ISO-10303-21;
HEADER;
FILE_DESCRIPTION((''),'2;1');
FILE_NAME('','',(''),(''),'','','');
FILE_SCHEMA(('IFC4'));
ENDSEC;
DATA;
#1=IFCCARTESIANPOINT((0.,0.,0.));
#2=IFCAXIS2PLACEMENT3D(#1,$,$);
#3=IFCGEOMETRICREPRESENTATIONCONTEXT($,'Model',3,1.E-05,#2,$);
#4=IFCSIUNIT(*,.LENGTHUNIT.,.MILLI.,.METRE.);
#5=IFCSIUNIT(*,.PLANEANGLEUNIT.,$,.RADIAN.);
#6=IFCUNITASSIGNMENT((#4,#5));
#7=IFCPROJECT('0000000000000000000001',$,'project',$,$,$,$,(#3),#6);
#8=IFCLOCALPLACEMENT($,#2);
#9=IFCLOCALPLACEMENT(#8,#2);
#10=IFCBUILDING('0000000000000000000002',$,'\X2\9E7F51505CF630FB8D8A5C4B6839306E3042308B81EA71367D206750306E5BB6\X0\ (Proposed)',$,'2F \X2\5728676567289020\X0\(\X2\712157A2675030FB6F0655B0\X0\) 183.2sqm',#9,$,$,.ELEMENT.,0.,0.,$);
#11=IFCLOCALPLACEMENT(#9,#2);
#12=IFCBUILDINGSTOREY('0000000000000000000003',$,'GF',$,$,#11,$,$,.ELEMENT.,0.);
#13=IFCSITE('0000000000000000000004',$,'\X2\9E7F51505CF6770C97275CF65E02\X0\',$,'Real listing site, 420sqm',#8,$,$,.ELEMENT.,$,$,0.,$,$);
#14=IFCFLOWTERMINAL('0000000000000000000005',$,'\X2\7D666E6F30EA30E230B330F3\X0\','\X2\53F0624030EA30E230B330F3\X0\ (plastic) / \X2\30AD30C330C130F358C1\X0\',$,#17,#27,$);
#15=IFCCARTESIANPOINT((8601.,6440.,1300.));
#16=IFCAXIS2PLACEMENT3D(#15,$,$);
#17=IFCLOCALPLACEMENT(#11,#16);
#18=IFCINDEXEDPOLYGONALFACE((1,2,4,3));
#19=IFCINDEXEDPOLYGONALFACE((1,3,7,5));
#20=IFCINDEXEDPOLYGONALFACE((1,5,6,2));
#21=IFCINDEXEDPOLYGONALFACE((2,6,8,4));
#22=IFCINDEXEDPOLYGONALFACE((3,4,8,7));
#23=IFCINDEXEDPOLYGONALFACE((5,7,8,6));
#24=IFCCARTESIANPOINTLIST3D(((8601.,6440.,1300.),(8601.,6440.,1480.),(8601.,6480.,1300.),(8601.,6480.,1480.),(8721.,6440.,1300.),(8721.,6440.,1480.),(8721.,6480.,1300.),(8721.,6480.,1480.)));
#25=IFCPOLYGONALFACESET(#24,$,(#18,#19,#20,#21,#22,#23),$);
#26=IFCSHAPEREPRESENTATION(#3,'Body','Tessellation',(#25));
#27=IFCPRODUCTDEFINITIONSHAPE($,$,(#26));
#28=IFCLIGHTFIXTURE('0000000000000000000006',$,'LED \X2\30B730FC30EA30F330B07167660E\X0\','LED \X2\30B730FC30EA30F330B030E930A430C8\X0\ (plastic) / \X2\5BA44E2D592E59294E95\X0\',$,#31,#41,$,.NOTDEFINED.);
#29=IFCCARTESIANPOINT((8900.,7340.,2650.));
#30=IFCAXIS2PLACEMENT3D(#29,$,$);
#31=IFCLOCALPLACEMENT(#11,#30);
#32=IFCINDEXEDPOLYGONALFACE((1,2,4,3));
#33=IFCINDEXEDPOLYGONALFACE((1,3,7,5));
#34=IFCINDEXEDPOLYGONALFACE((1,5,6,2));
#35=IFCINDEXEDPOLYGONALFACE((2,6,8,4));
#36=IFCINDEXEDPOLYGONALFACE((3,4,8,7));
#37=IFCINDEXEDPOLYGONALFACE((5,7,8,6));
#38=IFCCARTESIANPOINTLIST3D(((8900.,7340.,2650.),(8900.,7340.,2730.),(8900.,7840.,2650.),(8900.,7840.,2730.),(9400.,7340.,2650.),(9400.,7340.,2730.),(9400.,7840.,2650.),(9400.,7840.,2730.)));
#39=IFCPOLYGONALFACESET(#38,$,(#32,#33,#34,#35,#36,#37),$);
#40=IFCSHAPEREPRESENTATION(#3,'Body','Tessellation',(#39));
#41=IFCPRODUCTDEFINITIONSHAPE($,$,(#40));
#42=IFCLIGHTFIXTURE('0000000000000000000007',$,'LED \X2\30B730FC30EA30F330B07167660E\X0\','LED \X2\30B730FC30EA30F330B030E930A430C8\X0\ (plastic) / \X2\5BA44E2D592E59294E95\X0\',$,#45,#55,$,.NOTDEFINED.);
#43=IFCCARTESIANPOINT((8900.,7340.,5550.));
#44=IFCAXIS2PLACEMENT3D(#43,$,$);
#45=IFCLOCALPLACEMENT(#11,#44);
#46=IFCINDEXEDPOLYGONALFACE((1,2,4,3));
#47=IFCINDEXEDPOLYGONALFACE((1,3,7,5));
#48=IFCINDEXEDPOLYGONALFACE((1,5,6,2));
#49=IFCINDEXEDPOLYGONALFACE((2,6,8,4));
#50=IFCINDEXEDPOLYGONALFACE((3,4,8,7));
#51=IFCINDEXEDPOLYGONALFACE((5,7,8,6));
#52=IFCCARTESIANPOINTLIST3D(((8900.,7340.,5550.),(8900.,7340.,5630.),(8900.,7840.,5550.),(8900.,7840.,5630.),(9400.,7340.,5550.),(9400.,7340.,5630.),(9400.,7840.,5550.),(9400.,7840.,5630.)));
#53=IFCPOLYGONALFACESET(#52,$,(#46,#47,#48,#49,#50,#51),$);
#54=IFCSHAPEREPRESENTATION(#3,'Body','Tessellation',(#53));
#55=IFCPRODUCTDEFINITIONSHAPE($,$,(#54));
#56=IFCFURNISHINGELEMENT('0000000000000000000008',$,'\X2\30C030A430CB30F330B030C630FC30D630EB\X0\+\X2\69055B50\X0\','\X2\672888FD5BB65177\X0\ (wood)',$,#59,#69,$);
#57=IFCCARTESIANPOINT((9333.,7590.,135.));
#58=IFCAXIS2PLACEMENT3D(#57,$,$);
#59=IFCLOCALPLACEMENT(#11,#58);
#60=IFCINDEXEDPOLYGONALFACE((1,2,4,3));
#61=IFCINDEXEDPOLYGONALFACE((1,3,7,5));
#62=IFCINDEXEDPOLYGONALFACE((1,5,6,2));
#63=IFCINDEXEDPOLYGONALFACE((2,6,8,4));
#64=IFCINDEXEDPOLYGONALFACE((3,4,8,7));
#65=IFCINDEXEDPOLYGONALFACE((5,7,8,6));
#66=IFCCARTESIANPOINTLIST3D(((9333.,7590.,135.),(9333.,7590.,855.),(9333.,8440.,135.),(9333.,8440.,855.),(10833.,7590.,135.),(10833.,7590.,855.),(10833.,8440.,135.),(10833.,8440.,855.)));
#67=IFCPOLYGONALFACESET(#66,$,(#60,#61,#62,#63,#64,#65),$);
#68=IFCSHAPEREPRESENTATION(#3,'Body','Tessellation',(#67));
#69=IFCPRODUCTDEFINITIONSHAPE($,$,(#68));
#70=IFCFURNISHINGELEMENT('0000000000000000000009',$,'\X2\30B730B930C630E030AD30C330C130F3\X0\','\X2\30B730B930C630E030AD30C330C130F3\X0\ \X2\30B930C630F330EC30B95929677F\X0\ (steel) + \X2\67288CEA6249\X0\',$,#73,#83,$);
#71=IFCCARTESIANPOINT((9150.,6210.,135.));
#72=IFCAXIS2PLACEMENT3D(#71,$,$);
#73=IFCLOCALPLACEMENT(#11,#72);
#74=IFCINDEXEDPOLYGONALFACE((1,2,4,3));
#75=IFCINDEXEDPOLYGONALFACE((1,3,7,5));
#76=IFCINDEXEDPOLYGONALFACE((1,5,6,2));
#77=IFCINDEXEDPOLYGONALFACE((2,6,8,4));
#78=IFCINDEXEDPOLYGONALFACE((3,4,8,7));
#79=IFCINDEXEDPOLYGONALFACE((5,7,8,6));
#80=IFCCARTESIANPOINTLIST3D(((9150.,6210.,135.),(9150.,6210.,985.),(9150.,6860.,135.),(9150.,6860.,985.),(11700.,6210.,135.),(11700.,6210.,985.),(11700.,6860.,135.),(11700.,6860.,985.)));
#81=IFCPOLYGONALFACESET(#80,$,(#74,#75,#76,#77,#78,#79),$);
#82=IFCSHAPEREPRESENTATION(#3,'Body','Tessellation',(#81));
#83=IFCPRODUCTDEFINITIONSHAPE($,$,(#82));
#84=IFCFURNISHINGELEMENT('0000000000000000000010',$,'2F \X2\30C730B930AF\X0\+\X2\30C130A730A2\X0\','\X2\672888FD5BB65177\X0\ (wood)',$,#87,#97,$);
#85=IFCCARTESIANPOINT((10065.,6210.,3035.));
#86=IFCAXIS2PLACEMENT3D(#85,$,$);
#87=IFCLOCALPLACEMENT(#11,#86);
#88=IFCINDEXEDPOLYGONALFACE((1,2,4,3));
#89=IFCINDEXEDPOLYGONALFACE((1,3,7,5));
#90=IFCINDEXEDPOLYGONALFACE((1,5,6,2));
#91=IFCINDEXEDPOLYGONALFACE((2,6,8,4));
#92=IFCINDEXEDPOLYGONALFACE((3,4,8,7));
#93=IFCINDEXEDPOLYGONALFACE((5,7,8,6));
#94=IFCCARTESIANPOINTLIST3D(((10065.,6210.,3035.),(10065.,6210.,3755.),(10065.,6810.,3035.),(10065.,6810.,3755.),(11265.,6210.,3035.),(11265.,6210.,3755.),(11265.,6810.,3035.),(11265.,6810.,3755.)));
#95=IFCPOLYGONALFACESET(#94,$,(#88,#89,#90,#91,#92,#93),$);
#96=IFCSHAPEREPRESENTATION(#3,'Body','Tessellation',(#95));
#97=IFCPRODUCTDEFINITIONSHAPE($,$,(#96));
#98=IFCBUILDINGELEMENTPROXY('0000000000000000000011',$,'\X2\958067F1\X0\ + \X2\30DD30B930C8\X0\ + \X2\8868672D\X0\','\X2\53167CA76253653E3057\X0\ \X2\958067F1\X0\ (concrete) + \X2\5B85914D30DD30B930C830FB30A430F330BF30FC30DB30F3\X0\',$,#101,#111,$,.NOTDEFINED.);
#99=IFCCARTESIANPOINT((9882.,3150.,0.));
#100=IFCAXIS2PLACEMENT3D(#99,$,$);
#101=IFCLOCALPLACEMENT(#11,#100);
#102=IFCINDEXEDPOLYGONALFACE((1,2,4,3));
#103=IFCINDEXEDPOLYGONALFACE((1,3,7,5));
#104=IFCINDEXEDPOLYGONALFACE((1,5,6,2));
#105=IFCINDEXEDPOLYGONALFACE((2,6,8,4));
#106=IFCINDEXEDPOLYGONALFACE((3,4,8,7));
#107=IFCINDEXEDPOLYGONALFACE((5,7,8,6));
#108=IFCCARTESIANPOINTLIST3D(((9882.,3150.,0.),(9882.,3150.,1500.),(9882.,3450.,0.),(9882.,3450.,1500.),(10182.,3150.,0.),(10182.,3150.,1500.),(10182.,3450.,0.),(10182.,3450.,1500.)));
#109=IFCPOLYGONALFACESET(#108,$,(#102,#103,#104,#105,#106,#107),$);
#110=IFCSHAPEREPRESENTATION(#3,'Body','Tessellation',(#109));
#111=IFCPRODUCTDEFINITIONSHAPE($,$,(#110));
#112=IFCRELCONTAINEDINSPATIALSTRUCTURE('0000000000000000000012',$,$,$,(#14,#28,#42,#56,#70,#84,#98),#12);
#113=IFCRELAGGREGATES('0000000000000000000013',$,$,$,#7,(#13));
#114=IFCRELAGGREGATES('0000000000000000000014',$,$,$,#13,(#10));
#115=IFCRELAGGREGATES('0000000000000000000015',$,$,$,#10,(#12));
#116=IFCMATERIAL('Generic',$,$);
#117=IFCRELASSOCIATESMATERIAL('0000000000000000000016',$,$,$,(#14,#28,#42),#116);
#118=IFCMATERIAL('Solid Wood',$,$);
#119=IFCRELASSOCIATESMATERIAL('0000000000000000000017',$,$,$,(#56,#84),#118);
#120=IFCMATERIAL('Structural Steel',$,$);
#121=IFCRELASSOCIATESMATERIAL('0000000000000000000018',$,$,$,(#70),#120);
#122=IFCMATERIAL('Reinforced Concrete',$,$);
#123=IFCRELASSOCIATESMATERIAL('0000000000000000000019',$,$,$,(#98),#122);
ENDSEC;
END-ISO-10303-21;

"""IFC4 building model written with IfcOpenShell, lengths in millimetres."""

from ifc_helpers import new_model, si_unit, frame, frame_2d, origin, place, context, project, spatial, rectangle, extrude, material, element, save


model = new_model("IFC4")

# Units and contexts
model_context = context("Model", 3, precision=1e-05, world=origin())
ifc_project = project(units=[si_unit("LENGTHUNIT", "METRE", prefix="MILLI"), si_unit("PLANEANGLEUNIT", "RADIAN")], contexts=[model_context])

# Site, building, storey
site_placement = place(None, origin())
site = spatial("IfcSite", under=ifc_project, at=site_placement, Name="鹿児島県霧島市", ObjectType="Real listing site, 420sqm", CompositionType="ELEMENT", RefElevation=0.0)
building_placement = place(site_placement, origin())
building = spatial("IfcBuilding", under=site, at=building_placement, Name="鹿児島・越屋根のある自然素材の家 (Proposed)", ObjectType="2F 在来木造(無垢材・漆喰) 183.2sqm", CompositionType="ELEMENT", ElevationOfRefHeight=0.0, ElevationOfTerrain=0.0)
storey_placement = place(building_placement, origin())
storey = spatial("IfcBuildingStorey", under=building, at=storey_placement, Name="GF", CompositionType="ELEMENT", Elevation=0.0)

# Shared definitions
ifc_material_1 = material(Name="Solid Wood")

# Shared definitions
ifc_material_2 = material(Name="Structural Steel")

# Shared definitions
ifc_material_3 = material(Name="Reinforced Concrete")

# Flow terminal
ifc_material_4 = material(Name="Generic")
flow_terminal_1_placement = place(storey_placement, frame((8601.0, 6440.0, 1300.0)))
element("IfcFlowTerminal", 1, at=flow_terminal_1_placement, inside=storey, material=ifc_material_4, Name="給湯リモコン", Description="台所リモコン (plastic) / キッチン壁", context=model_context, shape_type="SweptSolid", body=[
    extrude(rectangle(XDim=120.0, YDim=40.0, at=frame_2d((60.0, 20.0))), frame((8601.0, 6440.0, 1300.0)), (0.0, 0.0, 1.0), 180.0),
])

# Light fixtures
light_fixture_1_placement = place(storey_placement, frame((8900.0, 7340.0, 2650.0)))
element("IfcLightFixture", 2, at=light_fixture_1_placement, inside=storey, material=ifc_material_4, Name="LED シーリング照明", Description="LED シーリングライト (plastic) / 室中央天井", PredefinedType="NOTDEFINED", context=model_context, shape_type="SweptSolid", body=[
    extrude(rectangle(XDim=500.0, YDim=500.0, at=frame_2d((250.0, 250.0))), frame((8900.0, 7340.0, 2650.0)), (0.0, 0.0, 1.0), 80.0),
])
light_fixture_2_placement = place(storey_placement, frame((8900.0, 7340.0, 5550.0)))
element("IfcLightFixture", 3, at=light_fixture_2_placement, inside=storey, material=ifc_material_4, Name="LED シーリング照明", Description="LED シーリングライト (plastic) / 室中央天井", PredefinedType="NOTDEFINED", context=model_context, shape_type="SweptSolid", body=[
    extrude(rectangle(XDim=500.0, YDim=500.0, at=frame_2d((250.0, 250.0))), frame((8900.0, 7340.0, 5550.0)), (0.0, 0.0, 1.0), 80.0),
])

# Furnishing elements
furnishing_1_placement = place(storey_placement, frame((9333.0, 7590.0, 135.0)))
element("IfcFurnishingElement", 4, at=furnishing_1_placement, inside=storey, material=ifc_material_1, Name="ダイニングテーブル+椅子", Description="木製家具 (wood)", context=model_context, shape_type="SweptSolid", body=[
    extrude(rectangle(XDim=1500.0, YDim=850.0, at=frame_2d((750.0, 425.0))), frame((9333.0, 7590.0, 135.0)), (0.0, 0.0, 1.0), 720.0),
])
furnishing_2_placement = place(storey_placement, frame((9150.0, 6210.0, 135.0)))
element("IfcFurnishingElement", 5, at=furnishing_2_placement, inside=storey, material=ifc_material_2, Name="システムキッチン", Description="システムキッチン ステンレス天板 (steel) + 木質扉", context=model_context, shape_type="SweptSolid", body=[
    extrude(rectangle(XDim=2550.0, YDim=650.0, at=frame_2d((1275.0, 325.0))), frame((9150.0, 6210.0, 135.0)), (0.0, 0.0, 1.0), 850.0),
])
furnishing_3_placement = place(storey_placement, frame((10065.0, 6210.0, 3035.0)))
element("IfcFurnishingElement", 6, at=furnishing_3_placement, inside=storey, material=ifc_material_1, Name="2F デスク+チェア", Description="木製家具 (wood)", context=model_context, shape_type="SweptSolid", body=[
    extrude(rectangle(XDim=1200.0, YDim=600.0, at=frame_2d((600.0, 300.0))), frame((10065.0, 6210.0, 3035.0)), (0.0, 0.0, 1.0), 720.0),
])

# Building element proxy
proxy_placement = place(storey_placement, frame((9882.0, 3150.0, 0.0)))
element("IfcBuildingElementProxy", 7, at=proxy_placement, inside=storey, material=ifc_material_3, Name="門柱 + ポスト + 表札", Description="化粧打放し 門柱 (concrete) + 宅配ポスト・インターホン", PredefinedType="NOTDEFINED", context=model_context, shape_type="SweptSolid", body=[
    extrude(rectangle(XDim=300.0, YDim=300.0, at=frame_2d((150.0, 150.0))), frame((9882.0, 3150.0, 0.0)), (0.0, 0.0, 1.0), 1500.0),
])

save(model, "model.ifc")
